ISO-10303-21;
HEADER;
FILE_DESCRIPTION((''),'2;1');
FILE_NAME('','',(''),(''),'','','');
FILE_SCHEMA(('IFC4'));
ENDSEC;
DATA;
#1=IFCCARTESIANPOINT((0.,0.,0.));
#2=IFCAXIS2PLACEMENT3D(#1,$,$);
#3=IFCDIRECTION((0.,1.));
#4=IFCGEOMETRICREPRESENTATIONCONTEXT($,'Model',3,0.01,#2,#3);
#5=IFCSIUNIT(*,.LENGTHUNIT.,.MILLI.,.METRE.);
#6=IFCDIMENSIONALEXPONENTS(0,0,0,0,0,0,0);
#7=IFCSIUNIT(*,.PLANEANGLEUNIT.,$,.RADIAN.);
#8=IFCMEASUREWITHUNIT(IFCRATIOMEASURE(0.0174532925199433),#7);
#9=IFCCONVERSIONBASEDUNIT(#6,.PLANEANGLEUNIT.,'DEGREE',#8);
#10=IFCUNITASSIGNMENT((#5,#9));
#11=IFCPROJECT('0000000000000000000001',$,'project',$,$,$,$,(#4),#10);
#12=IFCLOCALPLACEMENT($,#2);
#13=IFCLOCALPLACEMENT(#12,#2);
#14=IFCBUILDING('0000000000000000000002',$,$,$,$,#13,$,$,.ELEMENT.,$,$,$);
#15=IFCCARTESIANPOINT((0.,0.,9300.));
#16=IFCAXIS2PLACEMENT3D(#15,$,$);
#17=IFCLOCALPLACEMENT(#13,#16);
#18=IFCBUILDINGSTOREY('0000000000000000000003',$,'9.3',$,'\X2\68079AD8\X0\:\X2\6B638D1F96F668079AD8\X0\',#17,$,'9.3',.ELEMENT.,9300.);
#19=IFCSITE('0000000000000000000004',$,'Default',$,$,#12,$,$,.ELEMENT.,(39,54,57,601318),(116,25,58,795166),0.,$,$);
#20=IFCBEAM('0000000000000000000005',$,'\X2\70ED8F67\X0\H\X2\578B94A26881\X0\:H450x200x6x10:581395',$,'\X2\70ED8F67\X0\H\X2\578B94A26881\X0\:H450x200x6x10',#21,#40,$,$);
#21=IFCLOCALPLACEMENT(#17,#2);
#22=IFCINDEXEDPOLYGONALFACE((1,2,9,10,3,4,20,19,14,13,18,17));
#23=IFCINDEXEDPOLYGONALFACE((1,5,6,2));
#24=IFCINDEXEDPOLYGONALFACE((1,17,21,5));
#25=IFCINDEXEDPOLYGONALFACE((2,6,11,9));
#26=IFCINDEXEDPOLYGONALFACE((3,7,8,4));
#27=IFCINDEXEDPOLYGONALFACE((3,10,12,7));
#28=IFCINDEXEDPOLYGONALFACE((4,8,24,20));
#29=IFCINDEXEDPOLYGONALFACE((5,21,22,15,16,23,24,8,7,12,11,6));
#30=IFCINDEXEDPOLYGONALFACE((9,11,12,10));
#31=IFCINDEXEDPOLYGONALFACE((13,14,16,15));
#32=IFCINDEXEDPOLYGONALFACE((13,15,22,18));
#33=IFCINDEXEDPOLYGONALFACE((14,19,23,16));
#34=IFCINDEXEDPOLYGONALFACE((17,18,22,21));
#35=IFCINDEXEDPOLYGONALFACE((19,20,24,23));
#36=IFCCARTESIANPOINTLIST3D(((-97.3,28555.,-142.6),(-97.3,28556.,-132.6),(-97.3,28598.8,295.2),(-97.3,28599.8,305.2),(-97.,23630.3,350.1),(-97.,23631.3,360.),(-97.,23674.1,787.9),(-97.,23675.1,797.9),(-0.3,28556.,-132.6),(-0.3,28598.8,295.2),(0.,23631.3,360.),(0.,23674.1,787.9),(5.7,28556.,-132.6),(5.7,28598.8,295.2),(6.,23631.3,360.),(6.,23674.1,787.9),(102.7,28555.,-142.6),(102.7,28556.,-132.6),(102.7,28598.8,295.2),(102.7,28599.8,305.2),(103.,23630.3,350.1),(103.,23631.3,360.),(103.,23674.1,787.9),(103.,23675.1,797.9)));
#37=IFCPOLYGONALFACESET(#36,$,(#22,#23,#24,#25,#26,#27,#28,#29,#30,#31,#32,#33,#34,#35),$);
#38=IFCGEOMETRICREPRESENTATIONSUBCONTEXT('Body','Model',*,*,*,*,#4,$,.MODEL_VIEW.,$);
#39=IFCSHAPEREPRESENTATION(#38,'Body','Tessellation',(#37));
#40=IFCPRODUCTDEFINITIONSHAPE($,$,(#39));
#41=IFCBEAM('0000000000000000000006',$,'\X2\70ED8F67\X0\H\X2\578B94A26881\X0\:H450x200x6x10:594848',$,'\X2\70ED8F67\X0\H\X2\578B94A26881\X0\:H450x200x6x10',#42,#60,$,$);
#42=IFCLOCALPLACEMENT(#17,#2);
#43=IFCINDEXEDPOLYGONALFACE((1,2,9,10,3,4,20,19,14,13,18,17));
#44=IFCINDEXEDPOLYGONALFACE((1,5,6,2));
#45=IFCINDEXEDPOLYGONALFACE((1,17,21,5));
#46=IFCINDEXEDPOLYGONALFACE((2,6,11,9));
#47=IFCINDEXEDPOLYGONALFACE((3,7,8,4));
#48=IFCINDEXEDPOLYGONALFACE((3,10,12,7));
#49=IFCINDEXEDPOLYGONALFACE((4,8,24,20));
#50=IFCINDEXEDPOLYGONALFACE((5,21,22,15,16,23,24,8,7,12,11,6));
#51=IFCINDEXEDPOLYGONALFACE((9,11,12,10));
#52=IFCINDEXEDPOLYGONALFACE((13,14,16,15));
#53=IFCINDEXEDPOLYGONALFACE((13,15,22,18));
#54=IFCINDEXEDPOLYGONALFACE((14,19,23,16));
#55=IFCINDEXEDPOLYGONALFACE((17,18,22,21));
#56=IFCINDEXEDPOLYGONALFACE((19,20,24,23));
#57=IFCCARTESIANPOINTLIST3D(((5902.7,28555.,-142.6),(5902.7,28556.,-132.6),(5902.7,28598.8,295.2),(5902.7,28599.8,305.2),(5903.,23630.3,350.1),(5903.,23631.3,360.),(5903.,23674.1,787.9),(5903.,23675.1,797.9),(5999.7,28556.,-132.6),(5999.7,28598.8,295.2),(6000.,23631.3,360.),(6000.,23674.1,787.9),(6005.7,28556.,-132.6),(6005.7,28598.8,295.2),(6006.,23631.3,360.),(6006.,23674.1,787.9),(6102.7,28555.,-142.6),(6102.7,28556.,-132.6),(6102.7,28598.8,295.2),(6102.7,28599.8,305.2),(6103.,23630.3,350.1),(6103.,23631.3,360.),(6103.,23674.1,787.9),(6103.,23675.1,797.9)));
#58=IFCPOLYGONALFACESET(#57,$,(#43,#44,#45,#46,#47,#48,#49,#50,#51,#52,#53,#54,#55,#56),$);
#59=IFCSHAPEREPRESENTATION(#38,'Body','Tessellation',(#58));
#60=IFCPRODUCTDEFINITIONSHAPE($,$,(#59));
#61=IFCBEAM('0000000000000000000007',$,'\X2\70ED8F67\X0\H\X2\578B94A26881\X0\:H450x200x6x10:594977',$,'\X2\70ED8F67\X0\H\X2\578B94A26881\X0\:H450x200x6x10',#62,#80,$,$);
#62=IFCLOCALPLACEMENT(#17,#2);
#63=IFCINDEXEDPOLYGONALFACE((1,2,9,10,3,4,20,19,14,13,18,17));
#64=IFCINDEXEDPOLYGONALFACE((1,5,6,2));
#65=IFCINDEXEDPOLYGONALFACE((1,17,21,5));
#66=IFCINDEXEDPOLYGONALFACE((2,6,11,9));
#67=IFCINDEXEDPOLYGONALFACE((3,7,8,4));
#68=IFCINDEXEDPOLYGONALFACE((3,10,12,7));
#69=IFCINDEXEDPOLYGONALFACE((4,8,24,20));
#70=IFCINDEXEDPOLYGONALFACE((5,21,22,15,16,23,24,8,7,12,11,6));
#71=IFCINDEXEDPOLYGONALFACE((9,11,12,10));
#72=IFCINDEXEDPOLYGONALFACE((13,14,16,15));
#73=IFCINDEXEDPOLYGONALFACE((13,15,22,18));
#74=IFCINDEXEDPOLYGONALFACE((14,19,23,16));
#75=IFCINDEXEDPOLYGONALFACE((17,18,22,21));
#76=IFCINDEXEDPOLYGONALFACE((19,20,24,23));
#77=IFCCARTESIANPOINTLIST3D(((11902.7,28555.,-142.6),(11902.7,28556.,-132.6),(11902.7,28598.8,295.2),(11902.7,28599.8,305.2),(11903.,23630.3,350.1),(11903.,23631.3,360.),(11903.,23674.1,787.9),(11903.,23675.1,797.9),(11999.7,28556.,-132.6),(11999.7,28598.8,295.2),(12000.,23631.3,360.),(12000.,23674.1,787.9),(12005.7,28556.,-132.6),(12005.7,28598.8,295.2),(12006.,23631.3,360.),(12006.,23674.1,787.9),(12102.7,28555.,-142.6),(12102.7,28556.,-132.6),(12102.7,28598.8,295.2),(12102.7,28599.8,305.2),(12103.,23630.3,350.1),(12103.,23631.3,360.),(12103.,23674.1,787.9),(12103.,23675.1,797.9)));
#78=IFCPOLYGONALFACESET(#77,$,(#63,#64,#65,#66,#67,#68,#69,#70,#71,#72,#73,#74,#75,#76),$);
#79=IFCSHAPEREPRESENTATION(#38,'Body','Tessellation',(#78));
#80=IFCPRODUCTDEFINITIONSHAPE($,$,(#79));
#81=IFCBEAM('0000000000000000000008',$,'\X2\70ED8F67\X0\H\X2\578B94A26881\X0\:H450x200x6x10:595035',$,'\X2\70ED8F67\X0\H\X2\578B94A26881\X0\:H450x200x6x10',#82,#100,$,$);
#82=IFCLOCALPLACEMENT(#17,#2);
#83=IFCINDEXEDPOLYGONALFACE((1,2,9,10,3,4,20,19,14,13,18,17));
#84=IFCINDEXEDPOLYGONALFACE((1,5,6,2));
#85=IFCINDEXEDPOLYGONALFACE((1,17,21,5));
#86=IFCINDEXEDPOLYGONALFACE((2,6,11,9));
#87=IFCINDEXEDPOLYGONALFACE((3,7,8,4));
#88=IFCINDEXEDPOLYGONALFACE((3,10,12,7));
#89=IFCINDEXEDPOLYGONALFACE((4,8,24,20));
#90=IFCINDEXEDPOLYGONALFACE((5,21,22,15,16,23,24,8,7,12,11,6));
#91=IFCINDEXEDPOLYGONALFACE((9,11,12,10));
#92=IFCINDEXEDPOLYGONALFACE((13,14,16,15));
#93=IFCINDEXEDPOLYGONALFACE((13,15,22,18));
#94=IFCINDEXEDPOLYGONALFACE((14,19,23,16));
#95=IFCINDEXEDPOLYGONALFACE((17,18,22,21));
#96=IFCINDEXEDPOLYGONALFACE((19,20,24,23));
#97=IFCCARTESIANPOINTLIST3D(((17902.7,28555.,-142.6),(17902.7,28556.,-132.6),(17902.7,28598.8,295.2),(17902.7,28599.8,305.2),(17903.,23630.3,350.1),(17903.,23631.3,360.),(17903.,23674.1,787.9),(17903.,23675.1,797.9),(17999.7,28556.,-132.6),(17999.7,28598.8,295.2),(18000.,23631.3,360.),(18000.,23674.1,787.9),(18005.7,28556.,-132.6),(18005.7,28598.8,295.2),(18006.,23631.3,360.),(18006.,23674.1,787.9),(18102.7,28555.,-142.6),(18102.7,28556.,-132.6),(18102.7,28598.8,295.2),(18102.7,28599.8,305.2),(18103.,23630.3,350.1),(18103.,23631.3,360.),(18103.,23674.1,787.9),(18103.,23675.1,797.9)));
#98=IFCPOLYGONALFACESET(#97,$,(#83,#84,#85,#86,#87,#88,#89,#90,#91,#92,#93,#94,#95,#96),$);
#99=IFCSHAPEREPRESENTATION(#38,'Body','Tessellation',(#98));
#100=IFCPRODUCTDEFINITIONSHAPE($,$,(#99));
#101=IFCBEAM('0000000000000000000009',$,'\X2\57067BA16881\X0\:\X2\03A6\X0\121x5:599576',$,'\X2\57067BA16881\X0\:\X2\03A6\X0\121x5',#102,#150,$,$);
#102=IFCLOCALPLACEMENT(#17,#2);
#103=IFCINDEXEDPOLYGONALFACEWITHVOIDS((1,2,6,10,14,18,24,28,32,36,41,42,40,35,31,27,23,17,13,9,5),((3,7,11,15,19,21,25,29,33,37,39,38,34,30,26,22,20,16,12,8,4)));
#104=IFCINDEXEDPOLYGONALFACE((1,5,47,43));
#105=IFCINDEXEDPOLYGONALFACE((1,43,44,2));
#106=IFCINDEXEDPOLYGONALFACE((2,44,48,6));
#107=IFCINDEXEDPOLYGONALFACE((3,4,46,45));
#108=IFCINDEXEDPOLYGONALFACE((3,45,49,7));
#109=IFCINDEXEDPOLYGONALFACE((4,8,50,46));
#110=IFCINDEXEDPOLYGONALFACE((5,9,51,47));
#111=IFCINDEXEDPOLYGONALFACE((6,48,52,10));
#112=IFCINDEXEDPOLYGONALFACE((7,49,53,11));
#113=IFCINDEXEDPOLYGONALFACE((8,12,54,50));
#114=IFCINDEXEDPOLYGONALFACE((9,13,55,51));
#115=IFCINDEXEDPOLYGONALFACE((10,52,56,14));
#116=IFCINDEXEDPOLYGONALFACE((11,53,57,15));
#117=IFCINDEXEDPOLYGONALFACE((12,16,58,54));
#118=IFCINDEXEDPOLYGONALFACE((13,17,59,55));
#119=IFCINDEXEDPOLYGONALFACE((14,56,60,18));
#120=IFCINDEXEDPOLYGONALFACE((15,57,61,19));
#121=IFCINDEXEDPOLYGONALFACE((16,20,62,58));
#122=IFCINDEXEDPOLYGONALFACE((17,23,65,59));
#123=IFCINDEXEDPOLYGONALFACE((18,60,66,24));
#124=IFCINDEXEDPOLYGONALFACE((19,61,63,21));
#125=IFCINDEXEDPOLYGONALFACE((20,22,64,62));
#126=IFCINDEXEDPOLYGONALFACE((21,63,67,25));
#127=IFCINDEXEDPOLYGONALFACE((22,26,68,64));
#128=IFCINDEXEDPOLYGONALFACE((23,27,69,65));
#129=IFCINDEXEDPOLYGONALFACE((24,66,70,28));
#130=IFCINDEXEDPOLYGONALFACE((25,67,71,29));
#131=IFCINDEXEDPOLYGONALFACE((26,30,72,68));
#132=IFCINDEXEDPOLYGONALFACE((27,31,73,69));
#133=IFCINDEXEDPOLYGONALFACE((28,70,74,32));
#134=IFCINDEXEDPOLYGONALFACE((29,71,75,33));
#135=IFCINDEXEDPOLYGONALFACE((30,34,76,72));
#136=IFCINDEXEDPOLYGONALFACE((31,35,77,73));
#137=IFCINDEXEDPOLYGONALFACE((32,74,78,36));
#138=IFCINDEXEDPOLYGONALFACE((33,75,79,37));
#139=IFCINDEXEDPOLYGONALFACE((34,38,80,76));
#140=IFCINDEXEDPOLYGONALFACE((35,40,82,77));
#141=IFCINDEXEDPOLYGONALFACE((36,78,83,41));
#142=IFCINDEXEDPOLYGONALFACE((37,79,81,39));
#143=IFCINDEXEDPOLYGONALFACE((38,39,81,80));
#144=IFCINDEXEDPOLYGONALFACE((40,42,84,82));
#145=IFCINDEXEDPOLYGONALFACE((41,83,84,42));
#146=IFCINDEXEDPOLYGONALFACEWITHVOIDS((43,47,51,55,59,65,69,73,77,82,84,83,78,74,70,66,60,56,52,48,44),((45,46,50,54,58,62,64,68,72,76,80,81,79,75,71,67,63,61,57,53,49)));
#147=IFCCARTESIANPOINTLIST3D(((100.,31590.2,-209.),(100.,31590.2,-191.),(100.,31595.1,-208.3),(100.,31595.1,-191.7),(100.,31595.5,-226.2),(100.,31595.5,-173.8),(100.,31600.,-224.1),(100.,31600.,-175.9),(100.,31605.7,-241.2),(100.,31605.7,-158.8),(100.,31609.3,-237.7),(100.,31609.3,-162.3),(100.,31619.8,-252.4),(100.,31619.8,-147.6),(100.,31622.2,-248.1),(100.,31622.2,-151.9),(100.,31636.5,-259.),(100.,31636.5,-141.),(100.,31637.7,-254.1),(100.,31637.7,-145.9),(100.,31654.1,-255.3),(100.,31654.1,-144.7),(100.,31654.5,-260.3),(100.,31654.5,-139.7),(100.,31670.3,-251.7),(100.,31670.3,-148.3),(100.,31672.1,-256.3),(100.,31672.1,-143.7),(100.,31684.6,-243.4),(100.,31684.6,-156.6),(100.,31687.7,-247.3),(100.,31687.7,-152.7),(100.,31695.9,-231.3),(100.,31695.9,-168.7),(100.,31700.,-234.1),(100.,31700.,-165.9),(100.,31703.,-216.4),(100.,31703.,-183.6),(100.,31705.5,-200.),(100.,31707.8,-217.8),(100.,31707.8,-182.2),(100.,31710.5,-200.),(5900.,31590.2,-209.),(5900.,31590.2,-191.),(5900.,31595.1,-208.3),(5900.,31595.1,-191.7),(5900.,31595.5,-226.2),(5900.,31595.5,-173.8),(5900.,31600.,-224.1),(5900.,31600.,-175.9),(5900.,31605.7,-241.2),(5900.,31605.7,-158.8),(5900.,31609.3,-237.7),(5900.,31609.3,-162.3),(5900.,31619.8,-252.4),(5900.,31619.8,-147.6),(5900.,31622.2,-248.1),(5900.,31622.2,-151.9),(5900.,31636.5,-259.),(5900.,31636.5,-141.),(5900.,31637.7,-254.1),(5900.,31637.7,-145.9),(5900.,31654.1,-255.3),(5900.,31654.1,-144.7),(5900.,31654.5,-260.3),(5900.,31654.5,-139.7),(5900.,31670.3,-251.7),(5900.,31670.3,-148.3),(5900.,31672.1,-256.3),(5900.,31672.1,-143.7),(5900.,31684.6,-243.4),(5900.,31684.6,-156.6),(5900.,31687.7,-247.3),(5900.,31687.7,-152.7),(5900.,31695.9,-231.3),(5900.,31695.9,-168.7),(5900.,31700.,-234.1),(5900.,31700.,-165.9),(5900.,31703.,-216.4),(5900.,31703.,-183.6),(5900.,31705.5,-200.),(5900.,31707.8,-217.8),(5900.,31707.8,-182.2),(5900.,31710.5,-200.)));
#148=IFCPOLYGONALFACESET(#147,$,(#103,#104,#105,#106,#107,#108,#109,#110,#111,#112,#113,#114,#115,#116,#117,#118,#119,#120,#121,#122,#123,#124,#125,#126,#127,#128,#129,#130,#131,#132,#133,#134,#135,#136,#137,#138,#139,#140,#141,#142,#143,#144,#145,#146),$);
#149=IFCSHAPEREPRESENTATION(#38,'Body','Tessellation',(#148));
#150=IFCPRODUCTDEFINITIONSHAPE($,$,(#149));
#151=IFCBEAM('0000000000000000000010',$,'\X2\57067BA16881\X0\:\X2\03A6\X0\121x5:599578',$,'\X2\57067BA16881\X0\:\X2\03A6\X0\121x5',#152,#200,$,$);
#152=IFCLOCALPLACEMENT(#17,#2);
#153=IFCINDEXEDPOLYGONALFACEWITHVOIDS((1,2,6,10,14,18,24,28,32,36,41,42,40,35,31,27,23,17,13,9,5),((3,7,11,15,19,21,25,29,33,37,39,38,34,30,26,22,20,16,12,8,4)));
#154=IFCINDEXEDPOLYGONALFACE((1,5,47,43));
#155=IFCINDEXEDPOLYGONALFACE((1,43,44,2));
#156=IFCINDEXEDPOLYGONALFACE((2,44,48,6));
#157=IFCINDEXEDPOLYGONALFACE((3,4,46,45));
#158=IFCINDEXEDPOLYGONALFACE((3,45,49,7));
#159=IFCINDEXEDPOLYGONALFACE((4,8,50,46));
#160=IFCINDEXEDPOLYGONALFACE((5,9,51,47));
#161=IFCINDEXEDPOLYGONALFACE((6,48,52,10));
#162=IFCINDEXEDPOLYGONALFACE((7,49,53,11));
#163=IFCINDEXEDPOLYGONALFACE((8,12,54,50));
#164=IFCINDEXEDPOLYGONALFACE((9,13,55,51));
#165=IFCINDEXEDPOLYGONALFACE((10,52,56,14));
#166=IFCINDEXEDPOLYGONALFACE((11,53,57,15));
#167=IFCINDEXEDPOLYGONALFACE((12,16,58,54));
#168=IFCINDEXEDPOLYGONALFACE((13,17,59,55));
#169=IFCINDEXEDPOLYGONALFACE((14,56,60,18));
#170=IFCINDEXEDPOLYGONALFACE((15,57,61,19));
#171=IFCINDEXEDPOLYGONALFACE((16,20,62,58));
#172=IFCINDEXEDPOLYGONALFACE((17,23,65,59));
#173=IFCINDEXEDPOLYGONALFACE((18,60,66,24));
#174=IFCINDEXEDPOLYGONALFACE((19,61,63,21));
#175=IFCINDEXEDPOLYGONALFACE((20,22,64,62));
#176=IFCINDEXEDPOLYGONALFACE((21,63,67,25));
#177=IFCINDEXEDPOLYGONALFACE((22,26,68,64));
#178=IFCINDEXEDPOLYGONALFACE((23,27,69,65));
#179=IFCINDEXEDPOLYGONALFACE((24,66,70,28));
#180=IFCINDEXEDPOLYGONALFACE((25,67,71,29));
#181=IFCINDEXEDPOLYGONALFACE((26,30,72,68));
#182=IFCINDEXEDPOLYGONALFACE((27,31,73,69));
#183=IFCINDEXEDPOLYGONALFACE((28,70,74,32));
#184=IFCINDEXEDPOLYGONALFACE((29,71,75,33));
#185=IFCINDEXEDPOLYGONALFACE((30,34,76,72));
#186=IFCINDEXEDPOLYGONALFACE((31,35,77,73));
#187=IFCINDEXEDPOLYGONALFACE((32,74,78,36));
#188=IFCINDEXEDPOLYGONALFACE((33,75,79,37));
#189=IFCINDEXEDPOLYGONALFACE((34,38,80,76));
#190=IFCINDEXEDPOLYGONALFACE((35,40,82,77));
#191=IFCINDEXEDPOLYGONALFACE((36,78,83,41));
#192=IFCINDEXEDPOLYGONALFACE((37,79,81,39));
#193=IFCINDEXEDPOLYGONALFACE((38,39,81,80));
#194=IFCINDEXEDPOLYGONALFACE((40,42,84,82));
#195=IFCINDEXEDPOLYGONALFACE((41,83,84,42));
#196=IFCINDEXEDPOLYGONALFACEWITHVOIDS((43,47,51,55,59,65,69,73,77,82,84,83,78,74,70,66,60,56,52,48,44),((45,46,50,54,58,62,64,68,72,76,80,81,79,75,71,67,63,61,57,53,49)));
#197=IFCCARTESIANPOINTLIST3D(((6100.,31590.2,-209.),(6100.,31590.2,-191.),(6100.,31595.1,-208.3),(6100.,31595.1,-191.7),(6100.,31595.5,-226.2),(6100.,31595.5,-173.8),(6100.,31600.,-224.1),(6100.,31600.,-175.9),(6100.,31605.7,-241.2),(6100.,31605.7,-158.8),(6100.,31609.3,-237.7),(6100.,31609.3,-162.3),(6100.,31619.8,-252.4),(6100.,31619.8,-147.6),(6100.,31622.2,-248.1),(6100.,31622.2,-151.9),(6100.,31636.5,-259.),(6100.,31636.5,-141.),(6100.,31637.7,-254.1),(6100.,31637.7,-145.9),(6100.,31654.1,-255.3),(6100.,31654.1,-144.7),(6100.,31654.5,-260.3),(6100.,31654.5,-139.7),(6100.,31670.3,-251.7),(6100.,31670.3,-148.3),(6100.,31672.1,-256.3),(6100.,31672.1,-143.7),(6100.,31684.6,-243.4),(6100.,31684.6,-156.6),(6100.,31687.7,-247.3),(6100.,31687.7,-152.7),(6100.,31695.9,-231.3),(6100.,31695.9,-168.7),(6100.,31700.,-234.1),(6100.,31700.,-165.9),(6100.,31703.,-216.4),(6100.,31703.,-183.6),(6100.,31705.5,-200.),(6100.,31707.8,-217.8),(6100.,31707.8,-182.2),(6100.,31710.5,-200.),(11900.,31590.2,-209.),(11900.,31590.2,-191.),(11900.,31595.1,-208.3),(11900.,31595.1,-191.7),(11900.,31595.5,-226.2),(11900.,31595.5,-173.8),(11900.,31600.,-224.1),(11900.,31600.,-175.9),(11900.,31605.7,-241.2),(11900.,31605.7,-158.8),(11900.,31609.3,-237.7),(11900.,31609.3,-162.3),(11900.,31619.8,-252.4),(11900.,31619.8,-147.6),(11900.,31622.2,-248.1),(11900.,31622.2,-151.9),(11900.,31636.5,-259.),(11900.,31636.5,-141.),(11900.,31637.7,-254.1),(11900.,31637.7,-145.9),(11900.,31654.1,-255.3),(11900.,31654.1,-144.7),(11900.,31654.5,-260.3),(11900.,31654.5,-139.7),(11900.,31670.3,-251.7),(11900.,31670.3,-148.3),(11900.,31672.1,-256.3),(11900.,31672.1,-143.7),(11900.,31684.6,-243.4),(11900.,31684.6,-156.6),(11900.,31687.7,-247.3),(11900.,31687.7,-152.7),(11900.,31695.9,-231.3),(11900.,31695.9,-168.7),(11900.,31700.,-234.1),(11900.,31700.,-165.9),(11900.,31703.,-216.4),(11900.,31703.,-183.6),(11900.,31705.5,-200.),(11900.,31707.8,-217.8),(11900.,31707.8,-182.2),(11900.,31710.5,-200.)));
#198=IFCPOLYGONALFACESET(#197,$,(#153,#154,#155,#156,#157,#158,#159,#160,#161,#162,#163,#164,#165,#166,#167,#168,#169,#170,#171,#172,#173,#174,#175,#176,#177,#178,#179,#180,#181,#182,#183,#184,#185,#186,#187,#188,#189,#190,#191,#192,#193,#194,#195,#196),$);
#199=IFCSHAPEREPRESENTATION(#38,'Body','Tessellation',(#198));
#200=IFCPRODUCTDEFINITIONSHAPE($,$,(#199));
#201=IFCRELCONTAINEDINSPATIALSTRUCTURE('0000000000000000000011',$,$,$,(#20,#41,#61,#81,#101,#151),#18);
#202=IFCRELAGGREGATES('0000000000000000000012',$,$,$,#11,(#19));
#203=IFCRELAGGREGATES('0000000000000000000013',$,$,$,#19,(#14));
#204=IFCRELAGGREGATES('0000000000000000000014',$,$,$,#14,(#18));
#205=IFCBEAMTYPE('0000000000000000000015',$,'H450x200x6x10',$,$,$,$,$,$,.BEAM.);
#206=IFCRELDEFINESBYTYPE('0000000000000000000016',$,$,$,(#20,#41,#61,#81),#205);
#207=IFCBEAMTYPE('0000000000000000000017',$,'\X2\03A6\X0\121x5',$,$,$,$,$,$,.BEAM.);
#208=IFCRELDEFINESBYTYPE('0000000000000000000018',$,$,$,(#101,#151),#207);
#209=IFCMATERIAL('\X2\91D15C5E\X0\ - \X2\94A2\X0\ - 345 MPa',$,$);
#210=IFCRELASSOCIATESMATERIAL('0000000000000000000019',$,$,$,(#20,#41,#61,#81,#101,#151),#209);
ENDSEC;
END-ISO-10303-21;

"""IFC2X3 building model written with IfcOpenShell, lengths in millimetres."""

from ifc_helpers import new_model, entity, si_unit, converted_unit, direction, frame, frame_2d, origin, origin_2d_with_axis, place, context, subcontext, project, spatial, hollow_circle, i_section, extrude, material, type_object, element, save


model = new_model("IFC2X3")

# Units and contexts
model_context = context("Model", 3, precision=0.01, world=origin(), true_north=direction((0.0, 1.0)))
body_context = subcontext(model_context, "Body", "Model", "MODEL_VIEW")
ifc_project = project(units=[si_unit("LENGTHUNIT", "METRE", prefix="MILLI"), converted_unit("PLANEANGLEUNIT", "DEGREE", entity("IfcRatioMeasure", 0.0174532925199433), si_unit("PLANEANGLEUNIT", "RADIAN"), dimensions=[0, 0, 0, 0, 0, 0, 0])], contexts=[model_context])

# Site, building, storey
site_placement = place(None, origin())
site = spatial("IfcSite", under=ifc_project, at=site_placement, Name="Default", CompositionType="ELEMENT", RefLatitude=(39, 54, 57, 601318), RefLongitude=(116, 25, 58, 795166), RefElevation=0.0)
building_placement = place(site_placement, origin())
building = spatial("IfcBuilding", under=site, at=building_placement, CompositionType="ELEMENT")
storey_placement = place(building_placement, frame((0.0, 0.0, 9300.0)))
storey = spatial("IfcBuildingStorey", under=building, at=storey_placement, Name="9.3", ObjectType="标高:正负零标高", LongName="9.3", CompositionType="ELEMENT", Elevation=9300.0)

# Beams
ifc_material = material(Name="金属 - 钢 - 345 MPa")
beam_type_1 = type_object("IfcBeamType", Name="H450x200x6x10", PredefinedType="BEAM")
beam_1_placement = place(storey_placement, frame((2.7, 28615.0, 303.6), z_axis=(-0.000005, 0.099548, 0.995033), x_axis=(0.000053, -0.995033, 0.099548)))
element("IfcBeam", 1, at=beam_1_placement, inside=storey, type_object=beam_type_1, material=ifc_material, Name="热轧H型钢梁:H450x200x6x10:581395", ObjectType="热轧H型钢梁:H450x200x6x10", context=body_context, shape_type="SweptSolid", body=[
    extrude(i_section(OverallWidth=200.0, OverallDepth=450.0, WebThickness=6.0, FlangeThickness=10.0, at=frame_2d((0.0, 0.0), x_axis=(0.0, 1.0))), frame((15.3, 0.0, -225.0), z_axis=(1.0, 0.0, 0.0), x_axis=(0.0, 0.0, -1.0)), (0.0, 0.0, 1.0), 4949.3),
])
beam_2_placement = place(storey_placement, frame((6002.7, 28615.0, 303.6), z_axis=(-0.000005, 0.099548, 0.995033), x_axis=(0.000053, -0.995033, 0.099548)))
element("IfcBeam", 2, at=beam_2_placement, inside=storey, type_object=beam_type_1, material=ifc_material, Name="热轧H型钢梁:H450x200x6x10:594848", ObjectType="热轧H型钢梁:H450x200x6x10", context=body_context, shape_type="SweptSolid", body=[
    extrude(i_section(OverallWidth=200.0, OverallDepth=450.0, WebThickness=6.0, FlangeThickness=10.0, at=frame_2d((0.0, 0.0), x_axis=(0.0, 1.0))), frame((15.3, 0.0, -225.0), z_axis=(1.0, 0.0, 0.0), x_axis=(0.0, 0.0, -1.0)), (0.0, 0.0, 1.0), 4949.3),
])
beam_3_placement = place(storey_placement, frame((12002.7, 28615.0, 303.6), z_axis=(-0.000005, 0.099548, 0.995033), x_axis=(0.000053, -0.995033, 0.099548)))
element("IfcBeam", 3, at=beam_3_placement, inside=storey, type_object=beam_type_1, material=ifc_material, Name="热轧H型钢梁:H450x200x6x10:594977", ObjectType="热轧H型钢梁:H450x200x6x10", context=body_context, shape_type="SweptSolid", body=[
    extrude(i_section(OverallWidth=200.0, OverallDepth=450.0, WebThickness=6.0, FlangeThickness=10.0, at=frame_2d((0.0, 0.0), x_axis=(0.0, 1.0))), frame((15.3, 0.0, -225.0), z_axis=(1.0, 0.0, 0.0), x_axis=(0.0, 0.0, -1.0)), (0.0, 0.0, 1.0), 4949.3),
])
beam_4_placement = place(storey_placement, frame((18002.7, 28615.0, 303.6), z_axis=(-0.000005, 0.099548, 0.995033), x_axis=(0.000053, -0.995033, 0.099548)))
element("IfcBeam", 4, at=beam_4_placement, inside=storey, type_object=beam_type_1, material=ifc_material, Name="热轧H型钢梁:H450x200x6x10:595035", ObjectType="热轧H型钢梁:H450x200x6x10", context=body_context, shape_type="SweptSolid", body=[
    extrude(i_section(OverallWidth=200.0, OverallDepth=450.0, WebThickness=6.0, FlangeThickness=10.0, at=frame_2d((0.0, 0.0), x_axis=(0.0, 1.0))), frame((15.3, 0.0, -225.0), z_axis=(1.0, 0.0, 0.0), x_axis=(0.0, 0.0, -1.0)), (0.0, 0.0, 1.0), 4949.3),
])
beam_type_2 = type_object("IfcBeamType", Name="Φ121x5", PredefinedType="BEAM")
for number, where, name in (
    (5, (0.0, 31650.0, 0.0), "圆管梁:Φ121x5:599576"),
    (6, (6000.0, 31650.0, 0.0), "圆管梁:Φ121x5:599578"),
):
    element("IfcBeam", number, at=place(storey_placement, frame(where)), inside=storey, type_object=beam_type_2, material=ifc_material, Name=name, ObjectType="圆管梁:Φ121x5", context=body_context, shape_type="SweptSolid", body=[
        extrude(hollow_circle(Radius=60.5, WallThickness=5.0, at=origin_2d_with_axis()), frame((100.0, 0.0, -200.0), z_axis=(1.0, 0.0, 0.0), x_axis=(0.0, 1.0, 0.0)), (0.0, 0.0, 1.0), 5800.0),
    ])

save(model, "model.ifc")
